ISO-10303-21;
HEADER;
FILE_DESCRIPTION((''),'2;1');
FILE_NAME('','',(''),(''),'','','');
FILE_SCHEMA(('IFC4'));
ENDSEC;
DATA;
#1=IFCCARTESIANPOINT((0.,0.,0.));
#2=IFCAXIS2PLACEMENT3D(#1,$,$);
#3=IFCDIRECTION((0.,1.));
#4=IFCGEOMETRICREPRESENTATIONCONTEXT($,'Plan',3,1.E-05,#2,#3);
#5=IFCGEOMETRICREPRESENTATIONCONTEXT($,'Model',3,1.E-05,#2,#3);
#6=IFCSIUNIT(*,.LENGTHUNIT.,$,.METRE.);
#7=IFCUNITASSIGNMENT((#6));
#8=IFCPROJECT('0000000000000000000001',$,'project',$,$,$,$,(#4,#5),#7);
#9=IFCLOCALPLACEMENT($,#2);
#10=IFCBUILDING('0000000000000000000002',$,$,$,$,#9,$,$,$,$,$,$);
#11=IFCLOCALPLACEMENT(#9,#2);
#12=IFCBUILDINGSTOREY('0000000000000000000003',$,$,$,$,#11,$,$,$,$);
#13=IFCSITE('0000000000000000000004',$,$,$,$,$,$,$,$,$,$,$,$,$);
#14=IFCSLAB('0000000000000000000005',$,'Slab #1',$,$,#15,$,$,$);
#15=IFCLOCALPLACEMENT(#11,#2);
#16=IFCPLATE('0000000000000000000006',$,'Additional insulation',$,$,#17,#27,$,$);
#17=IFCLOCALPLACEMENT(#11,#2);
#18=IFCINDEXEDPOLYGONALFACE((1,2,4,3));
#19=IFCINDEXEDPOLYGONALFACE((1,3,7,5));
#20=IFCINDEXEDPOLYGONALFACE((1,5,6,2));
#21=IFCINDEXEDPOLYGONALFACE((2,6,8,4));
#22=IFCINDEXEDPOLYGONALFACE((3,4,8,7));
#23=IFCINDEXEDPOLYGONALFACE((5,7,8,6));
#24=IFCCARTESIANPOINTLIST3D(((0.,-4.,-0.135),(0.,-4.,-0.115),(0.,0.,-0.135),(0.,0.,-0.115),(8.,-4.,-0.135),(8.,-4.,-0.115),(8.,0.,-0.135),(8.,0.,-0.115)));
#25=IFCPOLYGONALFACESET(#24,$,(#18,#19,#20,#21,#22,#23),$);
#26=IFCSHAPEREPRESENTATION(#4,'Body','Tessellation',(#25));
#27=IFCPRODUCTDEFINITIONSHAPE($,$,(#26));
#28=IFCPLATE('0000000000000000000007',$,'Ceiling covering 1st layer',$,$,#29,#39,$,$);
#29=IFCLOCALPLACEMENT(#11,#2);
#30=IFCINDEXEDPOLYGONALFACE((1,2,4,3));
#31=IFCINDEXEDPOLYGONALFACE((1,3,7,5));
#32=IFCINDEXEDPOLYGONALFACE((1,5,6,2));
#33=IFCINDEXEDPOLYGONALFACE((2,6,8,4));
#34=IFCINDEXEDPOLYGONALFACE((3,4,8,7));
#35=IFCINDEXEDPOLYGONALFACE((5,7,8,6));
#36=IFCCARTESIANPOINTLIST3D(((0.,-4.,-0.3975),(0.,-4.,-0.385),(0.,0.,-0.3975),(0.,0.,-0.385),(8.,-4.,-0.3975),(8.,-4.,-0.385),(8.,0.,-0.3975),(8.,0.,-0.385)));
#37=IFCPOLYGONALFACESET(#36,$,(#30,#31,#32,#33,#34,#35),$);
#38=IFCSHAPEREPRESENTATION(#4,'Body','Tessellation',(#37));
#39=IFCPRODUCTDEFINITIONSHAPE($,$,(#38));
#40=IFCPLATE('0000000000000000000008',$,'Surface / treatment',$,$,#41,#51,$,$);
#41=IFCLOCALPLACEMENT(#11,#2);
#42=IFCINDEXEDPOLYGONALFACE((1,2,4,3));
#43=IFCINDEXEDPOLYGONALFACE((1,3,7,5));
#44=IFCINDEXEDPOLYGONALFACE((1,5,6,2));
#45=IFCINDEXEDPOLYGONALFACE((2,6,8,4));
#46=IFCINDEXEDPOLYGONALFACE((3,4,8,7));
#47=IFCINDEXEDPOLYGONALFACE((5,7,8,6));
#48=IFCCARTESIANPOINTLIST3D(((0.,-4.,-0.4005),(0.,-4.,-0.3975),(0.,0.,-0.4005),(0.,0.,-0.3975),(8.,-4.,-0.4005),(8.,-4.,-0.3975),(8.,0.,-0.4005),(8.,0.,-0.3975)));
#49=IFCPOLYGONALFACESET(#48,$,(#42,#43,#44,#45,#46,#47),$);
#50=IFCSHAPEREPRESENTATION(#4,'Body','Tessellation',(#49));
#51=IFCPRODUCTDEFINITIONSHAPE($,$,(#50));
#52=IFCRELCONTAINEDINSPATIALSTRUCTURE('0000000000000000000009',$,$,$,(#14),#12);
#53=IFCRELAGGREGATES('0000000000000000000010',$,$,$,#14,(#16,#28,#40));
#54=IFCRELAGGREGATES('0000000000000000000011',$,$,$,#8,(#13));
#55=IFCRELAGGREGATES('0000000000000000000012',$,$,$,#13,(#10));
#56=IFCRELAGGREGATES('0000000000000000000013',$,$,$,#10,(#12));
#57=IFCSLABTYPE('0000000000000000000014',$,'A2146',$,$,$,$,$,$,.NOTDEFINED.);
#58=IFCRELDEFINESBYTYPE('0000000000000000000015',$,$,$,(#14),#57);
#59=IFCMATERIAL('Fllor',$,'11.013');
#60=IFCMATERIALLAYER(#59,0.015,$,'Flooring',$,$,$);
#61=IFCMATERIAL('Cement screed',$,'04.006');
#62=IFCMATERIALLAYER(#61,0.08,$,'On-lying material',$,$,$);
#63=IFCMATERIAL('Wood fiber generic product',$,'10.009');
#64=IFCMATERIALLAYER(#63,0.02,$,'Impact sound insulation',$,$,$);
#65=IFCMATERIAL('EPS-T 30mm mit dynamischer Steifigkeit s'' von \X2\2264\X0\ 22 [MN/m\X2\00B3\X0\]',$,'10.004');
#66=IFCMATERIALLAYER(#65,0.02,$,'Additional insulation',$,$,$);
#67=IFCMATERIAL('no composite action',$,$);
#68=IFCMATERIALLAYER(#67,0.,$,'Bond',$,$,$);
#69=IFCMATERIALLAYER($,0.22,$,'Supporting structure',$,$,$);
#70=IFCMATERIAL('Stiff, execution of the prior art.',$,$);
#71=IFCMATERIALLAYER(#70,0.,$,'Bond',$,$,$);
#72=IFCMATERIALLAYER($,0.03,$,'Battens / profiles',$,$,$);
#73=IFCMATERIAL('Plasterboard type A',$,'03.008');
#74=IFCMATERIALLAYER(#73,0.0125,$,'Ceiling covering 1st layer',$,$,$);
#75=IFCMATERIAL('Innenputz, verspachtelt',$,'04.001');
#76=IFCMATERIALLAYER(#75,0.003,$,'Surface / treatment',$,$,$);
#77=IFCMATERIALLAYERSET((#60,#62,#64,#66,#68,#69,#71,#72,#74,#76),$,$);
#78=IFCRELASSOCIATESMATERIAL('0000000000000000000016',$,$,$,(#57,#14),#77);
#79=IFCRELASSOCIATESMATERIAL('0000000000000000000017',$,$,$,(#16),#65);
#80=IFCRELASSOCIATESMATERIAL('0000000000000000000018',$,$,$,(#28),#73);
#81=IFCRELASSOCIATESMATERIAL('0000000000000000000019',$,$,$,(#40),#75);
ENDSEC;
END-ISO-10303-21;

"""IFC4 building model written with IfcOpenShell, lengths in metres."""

from ifc_helpers import new_model, si_unit, direction, frame, frame_2d, origin, place, context, project, spatial, rectangle, extrude, material, layer, layer_set, type_object, element, aggregate, save


model = new_model("IFC4")

# Units and contexts
plan_context = context("Plan", 3, precision=1e-05, world=origin(), true_north=direction((0.0, 1.0)))
model_context = context("Model", 3, precision=1e-05, world=origin(), true_north=direction((0.0, 1.0)))
ifc_project = project(units=[si_unit("LENGTHUNIT", "METRE")], contexts=[plan_context, model_context])

# Site, building, storey
site = spatial("IfcSite", under=ifc_project)
building_placement = place(None, origin())
building = spatial("IfcBuilding", under=site, at=building_placement)
storey_placement = place(building_placement, origin())
storey = spatial("IfcBuildingStorey", under=building, at=storey_placement)

# Slab, plates
ifc_material_1 = material(Name="Fllor", Category="11.013")
ifc_layer_1 = layer(ifc_material_1, 0.015, Name="Flooring")
ifc_material_2 = material(Name="Cement screed", Category="04.006")
ifc_layer_2 = layer(ifc_material_2, 0.08, Name="On-lying material")
ifc_material_3 = material(Name="Wood fiber generic product", Category="10.009")
ifc_layer_3 = layer(ifc_material_3, 0.02, Name="Impact sound insulation")
ifc_material_4 = material(Name="EPS-T 30mm mit dynamischer Steifigkeit s' von ≤ 22 [MN/m³]", Category="10.004")
ifc_layer_4 = layer(ifc_material_4, 0.02, Name="Additional insulation")
ifc_material_5 = material(Name="no composite action")
ifc_layer_5 = layer(ifc_material_5, 0.0, Name="Bond")
ifc_layer_6 = layer(None, 0.22, Name="Supporting structure")
ifc_material_6 = material(Name="Stiff, execution of the prior art.")
ifc_layer_7 = layer(ifc_material_6, 0.0, Name="Bond")
ifc_layer_8 = layer(None, 0.03, Name="Battens / profiles")
ifc_material_7 = material(Name="Plasterboard type A", Category="03.008")
ifc_layer_9 = layer(ifc_material_7, 0.0125, Name="Ceiling covering 1st layer")
ifc_material_8 = material(Name="Innenputz, verspachtelt", Category="04.001")
ifc_layer_10 = layer(ifc_material_8, 0.003, Name="Surface / treatment")
ifc_layer_set = layer_set([ifc_layer_1, ifc_layer_2, ifc_layer_3, ifc_layer_4, ifc_layer_5, ifc_layer_6, ifc_layer_7, ifc_layer_8, ifc_layer_9, ifc_layer_10])
slab_type = type_object("IfcSlabType", Name="A2146", PredefinedType="NOTDEFINED", material=ifc_layer_set)
slab_placement = place(None, frame((0.0, 0.0, 0.0), z_axis=(0.0, 0.0, -1.0), x_axis=(1.0, 0.0, 0.0)))
slab = element("IfcSlab", 1, at=slab_placement, inside=storey, type_object=slab_type, material=ifc_layer_set, Name="Slab #1")
plate_1_placement = place(slab_placement, origin())
plate_1 = element("IfcPlate", 2, at=plate_1_placement, material=ifc_material_4, Name="Additional insulation", context=plan_context, shape_type="SweptSolid", body=[
    extrude(rectangle(XDim=8.0, YDim=4.0, at=frame_2d((4.0, 2.0), x_axis=(1.0, 0.0))), frame((0.0, 0.0, 0.115), z_axis=(0.0, 0.0, 1.0), x_axis=(1.0, 0.0, 0.0)), (0.0, 0.0, 1.0), 0.02),
])
plate_2_placement = place(slab_placement, origin())
plate_2 = element("IfcPlate", 3, at=plate_2_placement, material=ifc_material_7, Name="Ceiling covering 1st layer", context=plan_context, shape_type="SweptSolid", body=[
    extrude(rectangle(XDim=8.0, YDim=4.0, at=frame_2d((4.0, 2.0), x_axis=(1.0, 0.0))), frame((0.0, 0.0, 0.385), z_axis=(0.0, 0.0, 1.0), x_axis=(1.0, 0.0, 0.0)), (0.0, 0.0, 1.0), 0.0125),
])
plate_3_placement = place(slab_placement, origin())
plate_3 = element("IfcPlate", 4, at=plate_3_placement, material=ifc_material_8, Name="Surface / treatment", context=plan_context, shape_type="SweptSolid", body=[
    extrude(rectangle(XDim=8.0, YDim=4.0, at=frame_2d((4.0, 2.0), x_axis=(1.0, 0.0))), frame((0.0, 0.0, 0.3975), z_axis=(0.0, 0.0, 1.0), x_axis=(1.0, 0.0, 0.0)), (0.0, 0.0, 1.0), 0.003),
])
aggregate(slab, [plate_1, plate_2, plate_3])

save(model, "model.ifc")
